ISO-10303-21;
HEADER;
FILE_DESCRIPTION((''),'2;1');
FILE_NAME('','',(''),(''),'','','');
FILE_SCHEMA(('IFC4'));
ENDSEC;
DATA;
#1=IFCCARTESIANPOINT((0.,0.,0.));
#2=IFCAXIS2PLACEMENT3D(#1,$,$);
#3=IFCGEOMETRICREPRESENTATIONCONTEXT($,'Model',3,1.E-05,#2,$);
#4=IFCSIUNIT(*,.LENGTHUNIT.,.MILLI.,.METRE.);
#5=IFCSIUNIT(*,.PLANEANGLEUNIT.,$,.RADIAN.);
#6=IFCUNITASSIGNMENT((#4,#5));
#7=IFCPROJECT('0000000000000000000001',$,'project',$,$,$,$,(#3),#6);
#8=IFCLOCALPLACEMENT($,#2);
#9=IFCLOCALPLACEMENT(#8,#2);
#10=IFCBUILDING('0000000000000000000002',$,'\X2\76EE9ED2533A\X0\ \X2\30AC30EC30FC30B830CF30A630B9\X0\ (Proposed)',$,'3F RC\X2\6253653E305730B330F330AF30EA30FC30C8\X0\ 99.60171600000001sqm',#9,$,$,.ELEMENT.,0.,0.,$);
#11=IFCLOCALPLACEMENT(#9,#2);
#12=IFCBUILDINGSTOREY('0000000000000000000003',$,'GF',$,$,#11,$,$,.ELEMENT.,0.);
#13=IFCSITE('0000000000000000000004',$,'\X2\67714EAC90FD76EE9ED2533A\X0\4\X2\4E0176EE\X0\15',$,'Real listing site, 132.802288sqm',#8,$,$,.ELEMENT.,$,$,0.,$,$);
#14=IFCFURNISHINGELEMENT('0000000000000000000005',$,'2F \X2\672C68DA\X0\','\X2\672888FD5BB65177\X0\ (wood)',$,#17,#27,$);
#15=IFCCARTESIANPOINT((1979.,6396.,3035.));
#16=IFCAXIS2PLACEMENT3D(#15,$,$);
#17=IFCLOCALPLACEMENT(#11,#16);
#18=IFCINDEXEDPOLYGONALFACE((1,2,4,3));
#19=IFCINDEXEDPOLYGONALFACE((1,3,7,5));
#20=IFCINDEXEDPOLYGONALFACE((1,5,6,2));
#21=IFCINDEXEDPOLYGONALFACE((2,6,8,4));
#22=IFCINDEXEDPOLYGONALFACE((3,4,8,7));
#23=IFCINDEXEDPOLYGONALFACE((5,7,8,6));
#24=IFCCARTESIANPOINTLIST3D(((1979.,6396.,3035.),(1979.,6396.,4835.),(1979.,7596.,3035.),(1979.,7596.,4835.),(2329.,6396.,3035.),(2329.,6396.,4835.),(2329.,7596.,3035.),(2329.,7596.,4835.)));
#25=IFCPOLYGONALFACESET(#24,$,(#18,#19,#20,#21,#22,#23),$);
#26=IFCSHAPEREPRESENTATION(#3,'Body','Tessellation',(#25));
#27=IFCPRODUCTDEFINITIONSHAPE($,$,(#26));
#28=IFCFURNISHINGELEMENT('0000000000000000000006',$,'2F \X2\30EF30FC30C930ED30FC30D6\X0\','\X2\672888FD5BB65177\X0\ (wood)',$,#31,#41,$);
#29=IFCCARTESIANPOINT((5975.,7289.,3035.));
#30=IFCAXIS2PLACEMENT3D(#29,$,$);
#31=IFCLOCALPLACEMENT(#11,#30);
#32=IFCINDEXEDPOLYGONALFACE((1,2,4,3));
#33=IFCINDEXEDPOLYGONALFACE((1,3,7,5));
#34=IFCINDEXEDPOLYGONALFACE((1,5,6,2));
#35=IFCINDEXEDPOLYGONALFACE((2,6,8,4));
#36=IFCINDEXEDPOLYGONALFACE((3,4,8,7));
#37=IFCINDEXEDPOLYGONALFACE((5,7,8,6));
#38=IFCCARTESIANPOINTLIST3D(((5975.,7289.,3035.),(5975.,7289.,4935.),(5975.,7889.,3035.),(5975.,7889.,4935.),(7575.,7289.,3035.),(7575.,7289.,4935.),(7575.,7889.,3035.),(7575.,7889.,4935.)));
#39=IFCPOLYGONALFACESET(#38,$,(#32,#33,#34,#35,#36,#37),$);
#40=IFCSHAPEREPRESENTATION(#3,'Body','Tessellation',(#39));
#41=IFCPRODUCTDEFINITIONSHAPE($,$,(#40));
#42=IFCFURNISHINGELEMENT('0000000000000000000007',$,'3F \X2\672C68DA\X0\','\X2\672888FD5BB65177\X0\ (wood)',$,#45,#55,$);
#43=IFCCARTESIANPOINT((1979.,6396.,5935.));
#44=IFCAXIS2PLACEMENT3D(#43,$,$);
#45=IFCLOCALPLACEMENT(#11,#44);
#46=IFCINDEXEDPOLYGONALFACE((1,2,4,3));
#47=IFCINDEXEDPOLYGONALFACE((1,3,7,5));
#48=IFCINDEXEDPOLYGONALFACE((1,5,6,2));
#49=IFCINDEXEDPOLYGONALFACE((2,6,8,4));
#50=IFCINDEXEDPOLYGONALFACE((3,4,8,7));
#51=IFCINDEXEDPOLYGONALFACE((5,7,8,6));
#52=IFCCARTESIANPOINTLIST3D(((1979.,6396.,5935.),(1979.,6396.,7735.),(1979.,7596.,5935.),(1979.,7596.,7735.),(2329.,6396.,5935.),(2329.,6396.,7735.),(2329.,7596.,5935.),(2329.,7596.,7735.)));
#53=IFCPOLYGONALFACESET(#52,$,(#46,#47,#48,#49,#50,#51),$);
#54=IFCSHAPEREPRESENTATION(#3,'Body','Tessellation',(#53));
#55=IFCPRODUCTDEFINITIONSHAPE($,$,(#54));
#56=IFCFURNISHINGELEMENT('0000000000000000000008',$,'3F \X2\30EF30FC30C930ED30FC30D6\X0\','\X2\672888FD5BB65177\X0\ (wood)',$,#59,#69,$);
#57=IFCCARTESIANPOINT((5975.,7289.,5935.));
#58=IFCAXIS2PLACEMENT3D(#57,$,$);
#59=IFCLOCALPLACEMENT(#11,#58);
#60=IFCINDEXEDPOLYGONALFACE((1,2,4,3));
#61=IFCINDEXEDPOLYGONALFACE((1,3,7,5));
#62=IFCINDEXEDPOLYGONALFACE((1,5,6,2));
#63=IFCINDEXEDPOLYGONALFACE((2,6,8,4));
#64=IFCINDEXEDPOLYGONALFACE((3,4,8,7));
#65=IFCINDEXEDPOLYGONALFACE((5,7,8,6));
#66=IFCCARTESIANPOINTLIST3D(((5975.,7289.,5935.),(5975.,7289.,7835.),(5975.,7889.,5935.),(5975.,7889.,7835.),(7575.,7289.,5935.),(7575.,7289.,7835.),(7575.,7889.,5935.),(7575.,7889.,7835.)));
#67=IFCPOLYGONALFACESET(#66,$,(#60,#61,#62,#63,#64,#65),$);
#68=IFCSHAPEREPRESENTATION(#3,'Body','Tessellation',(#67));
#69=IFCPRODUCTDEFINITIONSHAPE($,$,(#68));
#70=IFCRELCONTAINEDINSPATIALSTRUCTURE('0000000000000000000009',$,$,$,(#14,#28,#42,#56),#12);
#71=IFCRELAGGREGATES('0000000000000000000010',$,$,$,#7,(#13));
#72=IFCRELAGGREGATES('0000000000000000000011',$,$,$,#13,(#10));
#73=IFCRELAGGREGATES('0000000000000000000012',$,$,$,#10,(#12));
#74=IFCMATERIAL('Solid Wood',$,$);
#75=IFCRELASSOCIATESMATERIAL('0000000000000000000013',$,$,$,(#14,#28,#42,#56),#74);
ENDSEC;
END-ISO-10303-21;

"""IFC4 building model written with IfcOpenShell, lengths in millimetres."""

from ifc_helpers import new_model, si_unit, frame, frame_2d, origin, place, context, project, spatial, rectangle, extrude, material, element, save


model = new_model("IFC4")

# Units and contexts
model_context = context("Model", 3, precision=1e-05, world=origin())
ifc_project = project(units=[si_unit("LENGTHUNIT", "METRE", prefix="MILLI"), si_unit("PLANEANGLEUNIT", "RADIAN")], contexts=[model_context])

# Site, building, storey
site_placement = place(None, origin())
site = spatial("IfcSite", under=ifc_project, at=site_placement, Name="東京都目黒区4丁目15", ObjectType="Real listing site, 132.802288sqm", CompositionType="ELEMENT", RefElevation=0.0)
building_placement = place(site_placement, origin())
building = spatial("IfcBuilding", under=site, at=building_placement, Name="目黒区 ガレージハウス (Proposed)", ObjectType="3F RC打放しコンクリート 99.60171600000001sqm", CompositionType="ELEMENT", ElevationOfRefHeight=0.0, ElevationOfTerrain=0.0)
storey_placement = place(building_placement, origin())
storey = spatial("IfcBuildingStorey", under=building, at=storey_placement, Name="GF", CompositionType="ELEMENT", Elevation=0.0)

# Shared definitions
ifc_material_1 = material(Name="Solid Wood")

# Furnishing elements
furnishing_1_placement = place(storey_placement, frame((1979.0, 6396.0, 3035.0)))
element("IfcFurnishingElement", 1, at=furnishing_1_placement, inside=storey, material=ifc_material_1, Name="2F 本棚", Description="木製家具 (wood)", context=model_context, shape_type="SweptSolid", body=[
    extrude(rectangle(XDim=350.0, YDim=1200.0, at=frame_2d((175.0, 600.0))), frame((1979.0, 6396.0, 3035.0)), (0.0, 0.0, 1.0), 1800.0),
])
furnishing_2_placement = place(storey_placement, frame((5975.0, 7289.0, 3035.0)))
element("IfcFurnishingElement", 2, at=furnishing_2_placement, inside=storey, material=ifc_material_1, Name="2F ワードローブ", Description="木製家具 (wood)", context=model_context, shape_type="SweptSolid", body=[
    extrude(rectangle(XDim=1600.0, YDim=600.0, at=frame_2d((800.0, 300.0))), frame((5975.0, 7289.0, 3035.0)), (0.0, 0.0, 1.0), 1900.0),
])
furnishing_3_placement = place(storey_placement, frame((1979.0, 6396.0, 5935.0)))
element("IfcFurnishingElement", 3, at=furnishing_3_placement, inside=storey, material=ifc_material_1, Name="3F 本棚", Description="木製家具 (wood)", context=model_context, shape_type="SweptSolid", body=[
    extrude(rectangle(XDim=350.0, YDim=1200.0, at=frame_2d((175.0, 600.0))), frame((1979.0, 6396.0, 5935.0)), (0.0, 0.0, 1.0), 1800.0),
])
furnishing_4_placement = place(storey_placement, frame((5975.0, 7289.0, 5935.0)))
element("IfcFurnishingElement", 4, at=furnishing_4_placement, inside=storey, material=ifc_material_1, Name="3F ワードローブ", Description="木製家具 (wood)", context=model_context, shape_type="SweptSolid", body=[
    extrude(rectangle(XDim=1600.0, YDim=600.0, at=frame_2d((800.0, 300.0))), frame((5975.0, 7289.0, 5935.0)), (0.0, 0.0, 1.0), 1900.0),
])

save(model, "model.ifc")
